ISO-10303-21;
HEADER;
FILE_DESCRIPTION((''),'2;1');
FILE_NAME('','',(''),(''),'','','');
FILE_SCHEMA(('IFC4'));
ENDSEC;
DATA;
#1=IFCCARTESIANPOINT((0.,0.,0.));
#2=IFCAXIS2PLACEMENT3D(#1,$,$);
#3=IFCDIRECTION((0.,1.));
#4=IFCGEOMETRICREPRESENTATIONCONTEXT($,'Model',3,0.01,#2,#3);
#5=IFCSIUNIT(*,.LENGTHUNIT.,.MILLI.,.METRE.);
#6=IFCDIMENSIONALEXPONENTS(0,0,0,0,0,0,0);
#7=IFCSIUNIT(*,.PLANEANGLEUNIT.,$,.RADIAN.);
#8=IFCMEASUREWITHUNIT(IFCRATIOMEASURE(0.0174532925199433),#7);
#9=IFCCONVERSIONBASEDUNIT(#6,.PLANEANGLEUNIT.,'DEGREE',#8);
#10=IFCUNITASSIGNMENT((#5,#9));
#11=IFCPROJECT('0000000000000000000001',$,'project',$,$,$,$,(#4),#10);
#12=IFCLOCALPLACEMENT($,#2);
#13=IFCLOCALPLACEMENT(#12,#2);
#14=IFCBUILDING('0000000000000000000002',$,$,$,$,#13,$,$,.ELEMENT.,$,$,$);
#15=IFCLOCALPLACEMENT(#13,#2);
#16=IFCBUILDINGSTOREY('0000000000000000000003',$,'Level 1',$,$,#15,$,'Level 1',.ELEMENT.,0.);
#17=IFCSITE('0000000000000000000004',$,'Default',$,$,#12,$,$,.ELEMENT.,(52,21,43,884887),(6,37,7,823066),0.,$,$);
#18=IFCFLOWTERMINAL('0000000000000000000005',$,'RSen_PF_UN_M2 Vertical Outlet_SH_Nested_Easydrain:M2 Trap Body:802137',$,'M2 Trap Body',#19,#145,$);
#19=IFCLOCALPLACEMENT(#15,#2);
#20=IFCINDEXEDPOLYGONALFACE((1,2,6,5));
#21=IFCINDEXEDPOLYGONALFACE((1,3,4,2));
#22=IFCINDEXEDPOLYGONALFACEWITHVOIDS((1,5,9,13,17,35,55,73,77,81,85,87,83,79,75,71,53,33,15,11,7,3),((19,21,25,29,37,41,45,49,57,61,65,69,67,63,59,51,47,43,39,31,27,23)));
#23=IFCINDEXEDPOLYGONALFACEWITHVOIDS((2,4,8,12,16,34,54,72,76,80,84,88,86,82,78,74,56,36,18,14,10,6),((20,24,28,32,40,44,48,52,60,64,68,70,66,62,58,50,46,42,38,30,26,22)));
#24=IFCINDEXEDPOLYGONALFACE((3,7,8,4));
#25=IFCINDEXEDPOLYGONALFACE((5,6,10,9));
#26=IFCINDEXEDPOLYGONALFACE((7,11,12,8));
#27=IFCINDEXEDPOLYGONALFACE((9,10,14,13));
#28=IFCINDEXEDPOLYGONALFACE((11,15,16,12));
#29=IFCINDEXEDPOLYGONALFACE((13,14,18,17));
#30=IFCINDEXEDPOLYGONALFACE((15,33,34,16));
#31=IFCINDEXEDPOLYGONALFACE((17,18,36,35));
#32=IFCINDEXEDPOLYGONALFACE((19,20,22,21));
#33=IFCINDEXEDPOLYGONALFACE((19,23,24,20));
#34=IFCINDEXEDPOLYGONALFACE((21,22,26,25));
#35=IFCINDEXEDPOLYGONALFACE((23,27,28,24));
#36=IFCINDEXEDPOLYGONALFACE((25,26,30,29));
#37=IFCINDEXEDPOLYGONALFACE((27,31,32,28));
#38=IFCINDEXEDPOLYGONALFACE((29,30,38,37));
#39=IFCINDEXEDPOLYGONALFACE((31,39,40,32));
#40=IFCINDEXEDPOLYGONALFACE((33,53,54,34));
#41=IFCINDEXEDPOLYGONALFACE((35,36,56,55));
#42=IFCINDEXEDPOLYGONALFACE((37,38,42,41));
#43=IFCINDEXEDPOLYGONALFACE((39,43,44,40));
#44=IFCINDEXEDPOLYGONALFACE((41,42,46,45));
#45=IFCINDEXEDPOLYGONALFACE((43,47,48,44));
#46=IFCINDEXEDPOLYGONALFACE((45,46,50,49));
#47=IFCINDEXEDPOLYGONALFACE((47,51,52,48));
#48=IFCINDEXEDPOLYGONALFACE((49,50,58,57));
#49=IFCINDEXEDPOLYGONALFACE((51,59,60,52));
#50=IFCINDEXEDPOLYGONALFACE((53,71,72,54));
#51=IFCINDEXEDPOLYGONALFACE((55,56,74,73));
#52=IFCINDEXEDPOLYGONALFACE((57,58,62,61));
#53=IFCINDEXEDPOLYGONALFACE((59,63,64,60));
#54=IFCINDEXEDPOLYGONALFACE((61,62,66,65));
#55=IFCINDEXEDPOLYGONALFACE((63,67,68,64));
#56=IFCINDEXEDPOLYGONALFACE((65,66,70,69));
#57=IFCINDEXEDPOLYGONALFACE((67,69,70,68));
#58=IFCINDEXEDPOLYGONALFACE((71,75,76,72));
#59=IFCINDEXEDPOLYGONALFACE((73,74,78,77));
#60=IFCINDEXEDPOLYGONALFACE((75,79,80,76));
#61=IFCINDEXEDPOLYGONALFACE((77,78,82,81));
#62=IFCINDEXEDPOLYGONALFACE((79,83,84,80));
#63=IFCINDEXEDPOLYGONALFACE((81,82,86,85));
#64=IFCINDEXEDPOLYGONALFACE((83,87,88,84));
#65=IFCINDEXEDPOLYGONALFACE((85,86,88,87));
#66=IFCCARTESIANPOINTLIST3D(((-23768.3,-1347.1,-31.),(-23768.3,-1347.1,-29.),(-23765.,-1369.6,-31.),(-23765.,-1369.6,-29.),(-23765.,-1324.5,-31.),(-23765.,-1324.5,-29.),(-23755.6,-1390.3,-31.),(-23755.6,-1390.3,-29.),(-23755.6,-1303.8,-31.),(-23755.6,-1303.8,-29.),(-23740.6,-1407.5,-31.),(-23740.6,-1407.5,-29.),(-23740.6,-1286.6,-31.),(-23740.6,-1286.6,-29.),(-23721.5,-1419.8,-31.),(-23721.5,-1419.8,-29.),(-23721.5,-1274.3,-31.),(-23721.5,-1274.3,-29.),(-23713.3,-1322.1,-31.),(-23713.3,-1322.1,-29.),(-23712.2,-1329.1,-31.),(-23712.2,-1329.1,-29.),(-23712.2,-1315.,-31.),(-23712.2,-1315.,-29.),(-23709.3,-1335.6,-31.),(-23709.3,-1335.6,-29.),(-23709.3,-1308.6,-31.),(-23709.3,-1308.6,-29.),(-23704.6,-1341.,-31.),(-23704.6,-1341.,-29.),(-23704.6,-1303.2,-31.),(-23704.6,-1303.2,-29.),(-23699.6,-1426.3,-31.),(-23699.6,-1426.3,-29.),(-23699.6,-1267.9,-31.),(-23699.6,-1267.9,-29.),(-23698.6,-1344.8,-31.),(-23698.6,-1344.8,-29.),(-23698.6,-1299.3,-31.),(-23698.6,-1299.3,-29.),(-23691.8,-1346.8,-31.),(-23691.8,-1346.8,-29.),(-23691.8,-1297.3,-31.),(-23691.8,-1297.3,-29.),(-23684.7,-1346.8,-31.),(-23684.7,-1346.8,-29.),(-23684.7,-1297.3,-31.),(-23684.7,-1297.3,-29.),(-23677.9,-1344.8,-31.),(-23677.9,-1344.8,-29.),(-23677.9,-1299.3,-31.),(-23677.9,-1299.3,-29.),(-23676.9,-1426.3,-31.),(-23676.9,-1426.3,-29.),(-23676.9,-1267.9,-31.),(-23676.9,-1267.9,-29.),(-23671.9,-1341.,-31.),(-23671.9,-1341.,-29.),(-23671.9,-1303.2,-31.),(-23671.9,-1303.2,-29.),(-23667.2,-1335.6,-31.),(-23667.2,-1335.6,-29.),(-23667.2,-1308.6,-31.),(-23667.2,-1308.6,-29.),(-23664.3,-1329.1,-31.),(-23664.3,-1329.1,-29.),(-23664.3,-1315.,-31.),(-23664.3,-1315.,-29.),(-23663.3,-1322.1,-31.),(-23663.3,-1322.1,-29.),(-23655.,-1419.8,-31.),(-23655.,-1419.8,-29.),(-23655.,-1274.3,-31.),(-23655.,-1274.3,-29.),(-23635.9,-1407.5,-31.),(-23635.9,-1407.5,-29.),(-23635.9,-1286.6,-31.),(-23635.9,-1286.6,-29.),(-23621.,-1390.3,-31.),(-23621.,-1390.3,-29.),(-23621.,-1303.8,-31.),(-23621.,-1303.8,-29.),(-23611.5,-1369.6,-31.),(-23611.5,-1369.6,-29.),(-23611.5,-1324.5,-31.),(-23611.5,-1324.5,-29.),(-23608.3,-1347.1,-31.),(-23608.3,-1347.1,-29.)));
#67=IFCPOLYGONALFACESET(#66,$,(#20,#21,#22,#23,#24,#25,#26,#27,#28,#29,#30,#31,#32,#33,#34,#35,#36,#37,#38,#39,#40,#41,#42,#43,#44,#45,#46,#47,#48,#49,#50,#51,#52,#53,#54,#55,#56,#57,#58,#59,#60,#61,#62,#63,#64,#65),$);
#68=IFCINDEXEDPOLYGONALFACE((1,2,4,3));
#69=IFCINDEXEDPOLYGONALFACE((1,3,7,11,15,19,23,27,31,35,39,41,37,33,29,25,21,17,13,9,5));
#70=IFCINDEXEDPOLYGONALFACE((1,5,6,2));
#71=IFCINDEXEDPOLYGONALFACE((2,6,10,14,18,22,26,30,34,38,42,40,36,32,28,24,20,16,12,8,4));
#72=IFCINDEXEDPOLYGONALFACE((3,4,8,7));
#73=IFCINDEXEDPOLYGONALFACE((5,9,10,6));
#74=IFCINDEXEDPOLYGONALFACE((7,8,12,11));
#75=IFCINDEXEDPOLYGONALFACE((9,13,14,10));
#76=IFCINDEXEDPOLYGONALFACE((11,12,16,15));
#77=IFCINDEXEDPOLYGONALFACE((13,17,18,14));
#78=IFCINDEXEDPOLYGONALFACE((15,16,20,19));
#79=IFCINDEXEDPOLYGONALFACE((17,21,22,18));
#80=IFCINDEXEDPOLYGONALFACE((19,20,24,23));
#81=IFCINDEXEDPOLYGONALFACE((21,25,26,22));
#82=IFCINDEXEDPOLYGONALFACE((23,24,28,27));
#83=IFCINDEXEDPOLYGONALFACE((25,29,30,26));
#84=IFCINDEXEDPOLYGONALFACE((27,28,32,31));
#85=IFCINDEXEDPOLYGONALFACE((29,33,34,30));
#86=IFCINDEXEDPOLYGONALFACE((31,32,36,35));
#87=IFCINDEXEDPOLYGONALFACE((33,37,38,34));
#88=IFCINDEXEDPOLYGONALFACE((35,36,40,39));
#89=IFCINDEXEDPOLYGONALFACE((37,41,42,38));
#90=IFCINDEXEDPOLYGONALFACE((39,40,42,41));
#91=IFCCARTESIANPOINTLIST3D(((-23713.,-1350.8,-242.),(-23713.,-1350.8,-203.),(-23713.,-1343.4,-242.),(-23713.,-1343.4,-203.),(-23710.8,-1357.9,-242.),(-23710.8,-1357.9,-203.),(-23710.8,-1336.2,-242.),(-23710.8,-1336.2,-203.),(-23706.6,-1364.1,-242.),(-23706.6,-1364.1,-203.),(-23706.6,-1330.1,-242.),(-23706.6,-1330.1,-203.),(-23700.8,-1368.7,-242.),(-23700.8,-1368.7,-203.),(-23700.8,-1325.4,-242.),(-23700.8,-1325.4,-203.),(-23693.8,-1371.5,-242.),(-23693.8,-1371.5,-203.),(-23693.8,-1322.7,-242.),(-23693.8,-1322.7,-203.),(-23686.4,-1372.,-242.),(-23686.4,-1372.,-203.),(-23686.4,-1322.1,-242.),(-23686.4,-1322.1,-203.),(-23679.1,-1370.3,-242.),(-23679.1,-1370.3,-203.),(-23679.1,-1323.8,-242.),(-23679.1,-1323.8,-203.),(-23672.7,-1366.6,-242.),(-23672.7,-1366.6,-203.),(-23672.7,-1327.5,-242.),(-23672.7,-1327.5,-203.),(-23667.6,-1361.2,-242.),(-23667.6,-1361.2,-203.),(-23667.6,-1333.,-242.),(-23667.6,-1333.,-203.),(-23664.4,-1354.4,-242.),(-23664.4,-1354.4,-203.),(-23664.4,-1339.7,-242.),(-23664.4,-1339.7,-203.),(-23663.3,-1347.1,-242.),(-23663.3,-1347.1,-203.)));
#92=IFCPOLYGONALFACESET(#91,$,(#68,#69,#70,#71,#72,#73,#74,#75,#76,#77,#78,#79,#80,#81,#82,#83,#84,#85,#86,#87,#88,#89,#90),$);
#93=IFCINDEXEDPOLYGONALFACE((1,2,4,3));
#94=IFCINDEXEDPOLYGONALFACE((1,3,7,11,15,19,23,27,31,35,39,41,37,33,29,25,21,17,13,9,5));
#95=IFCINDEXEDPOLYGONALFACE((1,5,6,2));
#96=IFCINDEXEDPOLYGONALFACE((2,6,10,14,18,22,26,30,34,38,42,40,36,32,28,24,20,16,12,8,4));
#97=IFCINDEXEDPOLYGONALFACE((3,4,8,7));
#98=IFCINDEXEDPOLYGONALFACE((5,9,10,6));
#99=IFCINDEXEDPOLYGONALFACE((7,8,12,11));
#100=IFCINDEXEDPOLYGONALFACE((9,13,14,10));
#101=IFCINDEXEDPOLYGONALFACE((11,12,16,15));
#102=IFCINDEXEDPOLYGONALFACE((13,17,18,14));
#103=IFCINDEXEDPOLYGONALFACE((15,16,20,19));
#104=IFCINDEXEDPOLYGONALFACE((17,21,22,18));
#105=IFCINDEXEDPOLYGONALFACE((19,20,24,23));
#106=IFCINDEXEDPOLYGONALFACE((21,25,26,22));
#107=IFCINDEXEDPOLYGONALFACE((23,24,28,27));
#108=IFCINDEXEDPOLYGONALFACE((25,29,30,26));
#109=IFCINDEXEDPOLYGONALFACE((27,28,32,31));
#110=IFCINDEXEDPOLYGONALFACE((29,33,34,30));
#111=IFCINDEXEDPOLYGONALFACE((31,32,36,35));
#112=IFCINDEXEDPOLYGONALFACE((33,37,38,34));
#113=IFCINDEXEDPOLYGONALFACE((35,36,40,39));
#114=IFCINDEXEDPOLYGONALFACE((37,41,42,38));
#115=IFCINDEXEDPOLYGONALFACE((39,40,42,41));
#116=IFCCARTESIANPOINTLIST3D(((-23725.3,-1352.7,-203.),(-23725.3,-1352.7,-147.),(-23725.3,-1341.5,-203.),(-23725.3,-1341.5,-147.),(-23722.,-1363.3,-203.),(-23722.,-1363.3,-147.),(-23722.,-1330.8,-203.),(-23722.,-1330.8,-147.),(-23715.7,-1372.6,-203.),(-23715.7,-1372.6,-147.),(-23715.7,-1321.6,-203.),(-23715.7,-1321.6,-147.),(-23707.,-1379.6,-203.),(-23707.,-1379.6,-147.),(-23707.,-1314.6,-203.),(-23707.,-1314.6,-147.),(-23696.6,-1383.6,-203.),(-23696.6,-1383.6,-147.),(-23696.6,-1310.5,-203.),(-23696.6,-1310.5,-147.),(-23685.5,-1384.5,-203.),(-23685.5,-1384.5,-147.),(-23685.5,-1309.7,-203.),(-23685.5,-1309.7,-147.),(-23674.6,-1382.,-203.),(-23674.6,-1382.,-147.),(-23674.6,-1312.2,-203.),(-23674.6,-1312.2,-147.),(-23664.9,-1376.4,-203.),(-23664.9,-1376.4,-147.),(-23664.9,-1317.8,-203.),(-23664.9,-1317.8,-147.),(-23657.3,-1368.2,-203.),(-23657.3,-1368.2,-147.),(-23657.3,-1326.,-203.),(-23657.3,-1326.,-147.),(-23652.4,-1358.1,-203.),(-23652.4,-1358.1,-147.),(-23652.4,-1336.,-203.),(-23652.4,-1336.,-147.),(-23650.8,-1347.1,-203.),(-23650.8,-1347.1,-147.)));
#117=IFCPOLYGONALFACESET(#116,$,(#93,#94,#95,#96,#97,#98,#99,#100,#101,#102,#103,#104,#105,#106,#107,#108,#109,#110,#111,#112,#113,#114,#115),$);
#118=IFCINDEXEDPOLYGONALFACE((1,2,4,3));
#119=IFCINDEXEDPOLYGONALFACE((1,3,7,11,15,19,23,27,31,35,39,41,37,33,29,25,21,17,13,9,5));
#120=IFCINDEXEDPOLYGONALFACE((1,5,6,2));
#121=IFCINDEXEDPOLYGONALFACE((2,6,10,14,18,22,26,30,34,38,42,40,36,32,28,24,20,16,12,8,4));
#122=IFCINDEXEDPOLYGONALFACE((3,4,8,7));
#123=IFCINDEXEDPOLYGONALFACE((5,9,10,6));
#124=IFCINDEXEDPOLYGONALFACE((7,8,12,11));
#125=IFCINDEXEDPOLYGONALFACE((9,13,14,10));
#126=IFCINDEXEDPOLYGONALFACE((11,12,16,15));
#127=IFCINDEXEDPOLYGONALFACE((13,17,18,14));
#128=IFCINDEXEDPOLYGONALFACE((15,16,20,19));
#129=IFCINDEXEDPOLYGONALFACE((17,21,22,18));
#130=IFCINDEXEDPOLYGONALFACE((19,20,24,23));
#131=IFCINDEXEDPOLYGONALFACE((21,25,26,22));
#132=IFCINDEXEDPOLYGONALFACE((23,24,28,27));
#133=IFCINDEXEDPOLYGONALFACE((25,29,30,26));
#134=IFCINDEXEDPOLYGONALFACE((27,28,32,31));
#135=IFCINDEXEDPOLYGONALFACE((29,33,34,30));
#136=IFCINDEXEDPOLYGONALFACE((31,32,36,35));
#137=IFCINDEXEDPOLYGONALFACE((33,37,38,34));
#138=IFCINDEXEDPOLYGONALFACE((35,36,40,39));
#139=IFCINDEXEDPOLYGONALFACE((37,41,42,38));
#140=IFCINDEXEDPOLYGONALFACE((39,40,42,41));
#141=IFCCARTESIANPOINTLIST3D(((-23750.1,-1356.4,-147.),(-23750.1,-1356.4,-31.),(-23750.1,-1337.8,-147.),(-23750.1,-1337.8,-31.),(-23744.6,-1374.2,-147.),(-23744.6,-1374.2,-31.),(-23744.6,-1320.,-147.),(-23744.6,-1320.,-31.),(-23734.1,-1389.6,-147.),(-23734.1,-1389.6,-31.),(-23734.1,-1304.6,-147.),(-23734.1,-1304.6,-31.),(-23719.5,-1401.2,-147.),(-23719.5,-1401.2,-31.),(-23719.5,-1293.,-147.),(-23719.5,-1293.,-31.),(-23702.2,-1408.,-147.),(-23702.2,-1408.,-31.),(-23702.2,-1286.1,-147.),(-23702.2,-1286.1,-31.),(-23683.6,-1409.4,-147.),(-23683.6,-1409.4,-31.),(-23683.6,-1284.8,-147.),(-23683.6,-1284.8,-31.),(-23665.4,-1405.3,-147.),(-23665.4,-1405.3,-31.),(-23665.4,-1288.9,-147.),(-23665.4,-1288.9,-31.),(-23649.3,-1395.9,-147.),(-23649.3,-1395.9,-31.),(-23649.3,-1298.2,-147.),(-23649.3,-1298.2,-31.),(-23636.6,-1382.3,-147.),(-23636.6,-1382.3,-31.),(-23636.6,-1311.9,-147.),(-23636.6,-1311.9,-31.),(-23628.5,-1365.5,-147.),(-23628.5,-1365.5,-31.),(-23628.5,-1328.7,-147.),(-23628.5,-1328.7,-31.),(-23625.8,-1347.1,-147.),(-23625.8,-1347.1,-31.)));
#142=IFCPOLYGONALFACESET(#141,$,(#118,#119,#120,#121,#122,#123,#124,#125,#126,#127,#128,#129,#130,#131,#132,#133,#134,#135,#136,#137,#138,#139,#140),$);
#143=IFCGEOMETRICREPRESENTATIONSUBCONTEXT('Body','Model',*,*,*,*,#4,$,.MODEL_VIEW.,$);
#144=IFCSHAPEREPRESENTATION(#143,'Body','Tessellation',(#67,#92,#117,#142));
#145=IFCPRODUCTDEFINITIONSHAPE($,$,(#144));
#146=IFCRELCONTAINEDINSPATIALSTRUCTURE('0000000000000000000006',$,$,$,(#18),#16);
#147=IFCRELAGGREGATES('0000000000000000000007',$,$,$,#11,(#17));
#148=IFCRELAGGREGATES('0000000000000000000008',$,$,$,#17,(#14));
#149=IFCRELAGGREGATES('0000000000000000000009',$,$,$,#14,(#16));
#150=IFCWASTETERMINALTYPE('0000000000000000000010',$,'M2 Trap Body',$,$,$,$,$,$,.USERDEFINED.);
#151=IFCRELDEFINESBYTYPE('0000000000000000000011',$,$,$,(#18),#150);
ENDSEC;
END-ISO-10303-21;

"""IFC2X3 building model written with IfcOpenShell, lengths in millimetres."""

from ifc_helpers import new_model, entity, si_unit, converted_unit, direction, frame, frame_2d, origin, origin_2d_with_axis, place, context, subcontext, project, spatial, circle_curve, parameter, trimmed, segment, composite_curve, circle, outline, extrude, source, transform, mapped, type_object, type_shapes, element, save


model = new_model("IFC2X3")

# Units and contexts
model_context = context("Model", 3, precision=0.01, world=origin(), true_north=direction((0.0, 1.0)))
body_context = subcontext(model_context, "Body", "Model", "MODEL_VIEW")
ifc_project = project(units=[si_unit("LENGTHUNIT", "METRE", prefix="MILLI"), converted_unit("PLANEANGLEUNIT", "DEGREE", entity("IfcRatioMeasure", 0.0174532925199433), si_unit("PLANEANGLEUNIT", "RADIAN"), dimensions=[0, 0, 0, 0, 0, 0, 0])], contexts=[model_context])

# Site, building, storey
site_placement = place(None, origin())
site = spatial("IfcSite", under=ifc_project, at=site_placement, Name="Default", CompositionType="ELEMENT", RefLatitude=(52, 21, 43, 884887), RefLongitude=(6, 37, 7, 823066), RefElevation=0.0)
building_placement = place(site_placement, origin())
building = spatial("IfcBuilding", under=site, at=building_placement, CompositionType="ELEMENT")
storey_placement = place(building_placement, origin())
storey = spatial("IfcBuildingStorey", under=building, at=storey_placement, Name="Level 1", LongName="Level 1", CompositionType="ELEMENT", Elevation=0.0)

# Flow terminal
waste_terminal_type_1 = type_object("IfcWasteTerminalType", Name="M2 Trap Body", PredefinedType="USERDEFINED")
shared_shape_1 = source(origin(), body_context, "Body", "SweptSolid", [
    extrude(outline(composite_curve([segment(trimmed(circle_curve(origin_2d_with_axis(), 80.0), [parameter(0.0)], [parameter(180.0)], True, "PARAMETER"), True, "CONTINUOUS"), segment(trimmed(circle_curve(origin_2d_with_axis(), 80.0), [parameter(180.0)], [parameter(360.0)], True, "PARAMETER"), True, "CONTINUOUS")], self_intersect=False), holes=[composite_curve([segment(trimmed(circle_curve(frame_2d((0.0, 25.0), x_axis=(1.0, 0.0)), 25.0), [parameter(180.0)], [parameter(360.0)], True, "PARAMETER"), False, "CONTINUOUS"), segment(trimmed(circle_curve(frame_2d((0.0, 25.0), x_axis=(1.0, 0.0)), 25.0), [parameter(0.0)], [parameter(180.0)], True, "PARAMETER"), False, "CONTINUOUS")], self_intersect=False)]), frame((0.0, -25.0, -2.0)), (0.0, 0.0, 1.0), 2.0),
    extrude(circle(Radius=25.0, at=frame_2d((0.0, 0.0), x_axis=(1.0, 0.0))), frame((0.0, -25.0, -213.0)), (0.0, 0.0, 1.0), 39.0),
    extrude(circle(Radius=37.5, at=frame_2d((0.0, 0.0), x_axis=(1.0, 0.0))), frame((0.0, -25.0, -174.0)), (0.0, 0.0, 1.0), 56.0),
    extrude(circle(Radius=62.5, at=frame_2d((0.0, 0.0), x_axis=(1.0, 0.0))), frame((0.0, -25.0, -118.0)), (0.0, 0.0, 1.0), 116.0),
])
type_shapes(waste_terminal_type_1, [shared_shape_1])
for number, where, name in (
    (1, (-23688.3, -1322.1, -29.0), "RSen_PF_UN_M2 Vertical Outlet_SH_Nested_Easydrain:M2 Trap Body:802137"),
):
    element("IfcFlowTerminal", number, at=place(storey_placement, frame(where)), inside=storey, type_object=waste_terminal_type_1, Name=name, ObjectType="M2 Trap Body", context=body_context, shape_type="MappedRepresentation", body=[
        mapped(shared_shape_1, transform((0.0, 0.0, 0.0), scale=1.0)),
    ])

save(model, "model.ifc")
